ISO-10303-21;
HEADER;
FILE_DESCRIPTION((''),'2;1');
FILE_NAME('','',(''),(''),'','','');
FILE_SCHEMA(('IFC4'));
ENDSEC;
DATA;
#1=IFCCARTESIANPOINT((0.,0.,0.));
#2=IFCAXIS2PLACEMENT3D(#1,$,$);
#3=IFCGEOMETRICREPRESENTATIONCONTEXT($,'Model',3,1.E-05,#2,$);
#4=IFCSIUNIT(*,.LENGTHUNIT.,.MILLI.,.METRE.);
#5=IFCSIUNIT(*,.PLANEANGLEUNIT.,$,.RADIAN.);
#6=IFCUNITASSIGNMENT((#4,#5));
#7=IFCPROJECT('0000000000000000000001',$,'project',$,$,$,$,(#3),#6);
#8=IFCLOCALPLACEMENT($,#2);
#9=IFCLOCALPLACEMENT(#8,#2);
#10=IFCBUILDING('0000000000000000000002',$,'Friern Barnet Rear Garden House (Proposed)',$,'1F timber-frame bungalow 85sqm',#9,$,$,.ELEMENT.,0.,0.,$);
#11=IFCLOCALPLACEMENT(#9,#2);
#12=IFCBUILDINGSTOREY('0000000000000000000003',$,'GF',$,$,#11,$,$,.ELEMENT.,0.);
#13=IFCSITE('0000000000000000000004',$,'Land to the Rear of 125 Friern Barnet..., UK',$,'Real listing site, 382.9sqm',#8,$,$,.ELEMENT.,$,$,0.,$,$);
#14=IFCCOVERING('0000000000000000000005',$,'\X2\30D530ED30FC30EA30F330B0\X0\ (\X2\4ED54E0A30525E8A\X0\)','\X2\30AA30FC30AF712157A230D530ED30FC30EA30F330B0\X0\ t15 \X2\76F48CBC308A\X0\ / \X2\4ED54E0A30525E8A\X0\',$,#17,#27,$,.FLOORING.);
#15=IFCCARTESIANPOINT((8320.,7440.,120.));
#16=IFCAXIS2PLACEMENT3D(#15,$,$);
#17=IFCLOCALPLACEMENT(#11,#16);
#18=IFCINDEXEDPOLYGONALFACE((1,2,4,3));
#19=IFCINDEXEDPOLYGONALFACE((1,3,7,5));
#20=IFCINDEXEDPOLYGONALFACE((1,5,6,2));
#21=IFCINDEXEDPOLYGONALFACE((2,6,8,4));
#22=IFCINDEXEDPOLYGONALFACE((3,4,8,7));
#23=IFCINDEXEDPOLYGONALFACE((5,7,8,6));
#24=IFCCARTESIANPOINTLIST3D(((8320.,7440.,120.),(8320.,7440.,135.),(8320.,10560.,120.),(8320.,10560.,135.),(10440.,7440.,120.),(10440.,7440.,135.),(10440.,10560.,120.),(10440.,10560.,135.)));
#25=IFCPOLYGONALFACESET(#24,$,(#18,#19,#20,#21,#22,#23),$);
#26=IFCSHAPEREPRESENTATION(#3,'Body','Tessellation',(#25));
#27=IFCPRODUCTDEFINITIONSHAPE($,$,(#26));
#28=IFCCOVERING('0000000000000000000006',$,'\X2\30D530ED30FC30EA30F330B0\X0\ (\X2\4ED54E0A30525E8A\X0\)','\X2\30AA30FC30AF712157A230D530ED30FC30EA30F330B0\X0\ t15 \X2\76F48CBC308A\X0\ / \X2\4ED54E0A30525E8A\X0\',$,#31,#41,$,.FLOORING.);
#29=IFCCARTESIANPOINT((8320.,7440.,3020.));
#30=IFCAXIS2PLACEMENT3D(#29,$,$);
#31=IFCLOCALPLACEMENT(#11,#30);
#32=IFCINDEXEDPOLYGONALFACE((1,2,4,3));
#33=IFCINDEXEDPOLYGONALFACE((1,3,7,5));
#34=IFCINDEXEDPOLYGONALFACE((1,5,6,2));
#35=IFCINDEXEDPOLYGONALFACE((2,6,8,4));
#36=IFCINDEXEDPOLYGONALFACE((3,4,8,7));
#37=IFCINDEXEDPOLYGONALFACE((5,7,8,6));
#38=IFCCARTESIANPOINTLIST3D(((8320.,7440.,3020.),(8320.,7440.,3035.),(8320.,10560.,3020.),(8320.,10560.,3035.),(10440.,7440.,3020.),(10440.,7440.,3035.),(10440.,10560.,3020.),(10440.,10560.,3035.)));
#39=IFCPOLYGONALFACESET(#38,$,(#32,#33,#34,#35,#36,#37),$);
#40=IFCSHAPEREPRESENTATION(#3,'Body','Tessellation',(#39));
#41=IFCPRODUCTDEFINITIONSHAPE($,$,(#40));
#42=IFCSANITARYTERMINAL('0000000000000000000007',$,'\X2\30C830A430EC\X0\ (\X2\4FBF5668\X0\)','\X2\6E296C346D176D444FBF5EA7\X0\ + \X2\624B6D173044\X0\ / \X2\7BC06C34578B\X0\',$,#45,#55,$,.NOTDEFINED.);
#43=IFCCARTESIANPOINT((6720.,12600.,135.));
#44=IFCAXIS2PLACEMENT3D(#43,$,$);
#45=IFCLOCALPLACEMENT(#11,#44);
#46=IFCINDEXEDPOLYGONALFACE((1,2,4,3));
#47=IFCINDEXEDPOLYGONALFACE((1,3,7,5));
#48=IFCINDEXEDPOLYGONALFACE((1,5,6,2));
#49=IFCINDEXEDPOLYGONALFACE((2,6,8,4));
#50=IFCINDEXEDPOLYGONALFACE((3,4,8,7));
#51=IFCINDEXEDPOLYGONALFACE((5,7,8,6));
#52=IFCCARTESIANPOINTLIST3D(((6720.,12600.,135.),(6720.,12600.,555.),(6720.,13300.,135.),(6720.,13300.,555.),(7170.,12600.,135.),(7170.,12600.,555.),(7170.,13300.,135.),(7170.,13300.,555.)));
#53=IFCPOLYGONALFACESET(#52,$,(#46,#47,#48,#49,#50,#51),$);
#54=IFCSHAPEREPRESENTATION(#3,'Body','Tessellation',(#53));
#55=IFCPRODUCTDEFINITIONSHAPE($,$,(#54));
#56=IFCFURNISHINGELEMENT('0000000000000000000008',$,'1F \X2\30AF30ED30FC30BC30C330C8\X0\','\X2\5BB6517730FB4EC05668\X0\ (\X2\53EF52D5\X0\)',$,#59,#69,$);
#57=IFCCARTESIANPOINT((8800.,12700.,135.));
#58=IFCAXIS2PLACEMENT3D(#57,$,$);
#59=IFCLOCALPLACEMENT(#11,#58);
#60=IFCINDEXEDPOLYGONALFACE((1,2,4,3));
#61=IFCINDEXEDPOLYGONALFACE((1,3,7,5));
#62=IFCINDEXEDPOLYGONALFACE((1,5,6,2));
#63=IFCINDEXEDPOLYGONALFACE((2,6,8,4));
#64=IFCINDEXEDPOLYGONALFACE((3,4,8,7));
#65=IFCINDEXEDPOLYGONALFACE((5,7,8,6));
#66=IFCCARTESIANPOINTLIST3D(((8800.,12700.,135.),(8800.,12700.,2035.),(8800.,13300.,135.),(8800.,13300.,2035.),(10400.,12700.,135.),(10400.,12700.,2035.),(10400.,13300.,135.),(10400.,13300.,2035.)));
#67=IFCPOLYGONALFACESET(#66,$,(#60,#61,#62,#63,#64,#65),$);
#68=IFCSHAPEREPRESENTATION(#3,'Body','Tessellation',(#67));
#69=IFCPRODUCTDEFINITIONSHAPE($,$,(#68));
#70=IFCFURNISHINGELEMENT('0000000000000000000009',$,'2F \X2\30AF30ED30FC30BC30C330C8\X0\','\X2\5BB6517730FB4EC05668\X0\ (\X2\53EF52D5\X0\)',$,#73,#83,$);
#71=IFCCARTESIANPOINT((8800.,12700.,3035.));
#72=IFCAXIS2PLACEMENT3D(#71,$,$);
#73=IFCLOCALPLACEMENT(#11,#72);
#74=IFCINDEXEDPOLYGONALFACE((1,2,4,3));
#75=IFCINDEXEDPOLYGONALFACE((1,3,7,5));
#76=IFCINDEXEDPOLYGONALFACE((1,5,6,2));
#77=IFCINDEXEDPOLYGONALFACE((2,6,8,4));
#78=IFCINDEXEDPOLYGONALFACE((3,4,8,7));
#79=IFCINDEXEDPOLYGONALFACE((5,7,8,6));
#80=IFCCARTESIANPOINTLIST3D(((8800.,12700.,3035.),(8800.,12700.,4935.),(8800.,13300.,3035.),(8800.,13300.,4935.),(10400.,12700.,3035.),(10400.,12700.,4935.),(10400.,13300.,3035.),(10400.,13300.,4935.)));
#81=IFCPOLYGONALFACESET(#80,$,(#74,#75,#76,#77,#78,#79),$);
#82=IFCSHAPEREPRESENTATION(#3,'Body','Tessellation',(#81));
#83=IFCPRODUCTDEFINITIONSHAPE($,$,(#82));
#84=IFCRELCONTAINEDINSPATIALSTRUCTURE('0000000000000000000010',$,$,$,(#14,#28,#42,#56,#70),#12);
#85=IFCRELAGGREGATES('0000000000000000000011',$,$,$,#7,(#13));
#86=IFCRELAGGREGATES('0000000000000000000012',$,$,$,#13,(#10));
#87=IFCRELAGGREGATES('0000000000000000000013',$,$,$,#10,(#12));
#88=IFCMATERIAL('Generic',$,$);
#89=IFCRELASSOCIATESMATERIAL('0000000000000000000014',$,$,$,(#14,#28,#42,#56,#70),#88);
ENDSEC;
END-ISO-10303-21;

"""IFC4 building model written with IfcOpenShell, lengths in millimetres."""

from ifc_helpers import new_model, si_unit, frame, frame_2d, origin, place, context, project, spatial, rectangle, extrude, material, element, save


model = new_model("IFC4")

# Units and contexts
model_context = context("Model", 3, precision=1e-05, world=origin())
ifc_project = project(units=[si_unit("LENGTHUNIT", "METRE", prefix="MILLI"), si_unit("PLANEANGLEUNIT", "RADIAN")], contexts=[model_context])

# Site, building, storey
site_placement = place(None, origin())
site = spatial("IfcSite", under=ifc_project, at=site_placement, Name="Land to the Rear of 125 Friern Barnet..., UK", ObjectType="Real listing site, 382.9sqm", CompositionType="ELEMENT", RefElevation=0.0)
building_placement = place(site_placement, origin())
building = spatial("IfcBuilding", under=site, at=building_placement, Name="Friern Barnet Rear Garden House (Proposed)", ObjectType="1F timber-frame bungalow 85sqm", CompositionType="ELEMENT", ElevationOfRefHeight=0.0, ElevationOfTerrain=0.0)
storey_placement = place(building_placement, origin())
storey = spatial("IfcBuildingStorey", under=building, at=storey_placement, Name="GF", CompositionType="ELEMENT", Elevation=0.0)

# Shared definitions
ifc_material_1 = material(Name="Generic")

# Coverings
covering_1_placement = place(storey_placement, frame((8320.0, 7440.0, 120.0)))
element("IfcCovering", 1, at=covering_1_placement, inside=storey, material=ifc_material_1, Name="フローリング (仕上げ床)", Description="オーク無垢フローリング t15 直貼り / 仕上げ床", PredefinedType="FLOORING", context=model_context, shape_type="SweptSolid", body=[
    extrude(rectangle(XDim=2120.0, YDim=3120.0, at=frame_2d((1060.0, 1560.0))), frame((8320.0, 7440.0, 120.0)), (0.0, 0.0, 1.0), 15.0),
])
covering_2_placement = place(storey_placement, frame((8320.0, 7440.0, 3020.0)))
element("IfcCovering", 2, at=covering_2_placement, inside=storey, material=ifc_material_1, Name="フローリング (仕上げ床)", Description="オーク無垢フローリング t15 直貼り / 仕上げ床", PredefinedType="FLOORING", context=model_context, shape_type="SweptSolid", body=[
    extrude(rectangle(XDim=2120.0, YDim=3120.0, at=frame_2d((1060.0, 1560.0))), frame((8320.0, 7440.0, 3020.0)), (0.0, 0.0, 1.0), 15.0),
])

# Sanitary terminal
sanitary_terminal_placement = place(storey_placement, frame((6720.0, 12600.0, 135.0)))
element("IfcSanitaryTerminal", 3, at=sanitary_terminal_placement, inside=storey, material=ifc_material_1, Name="トイレ (便器)", Description="温水洗浄便座 + 手洗い / 節水型", PredefinedType="NOTDEFINED", context=model_context, shape_type="SweptSolid", body=[
    extrude(rectangle(XDim=450.0, YDim=700.0, at=frame_2d((225.0, 350.0))), frame((6720.0, 12600.0, 135.0)), (0.0, 0.0, 1.0), 420.0),
])

# Furnishing elements
furnishing_1_placement = place(storey_placement, frame((8800.0, 12700.0, 135.0)))
element("IfcFurnishingElement", 4, at=furnishing_1_placement, inside=storey, material=ifc_material_1, Name="1F クローゼット", Description="家具・什器 (可動)", context=model_context, shape_type="SweptSolid", body=[
    extrude(rectangle(XDim=1600.0, YDim=600.0, at=frame_2d((800.0, 300.0))), frame((8800.0, 12700.0, 135.0)), (0.0, 0.0, 1.0), 1900.0),
])
furnishing_2_placement = place(storey_placement, frame((8800.0, 12700.0, 3035.0)))
element("IfcFurnishingElement", 5, at=furnishing_2_placement, inside=storey, material=ifc_material_1, Name="2F クローゼット", Description="家具・什器 (可動)", context=model_context, shape_type="SweptSolid", body=[
    extrude(rectangle(XDim=1600.0, YDim=600.0, at=frame_2d((800.0, 300.0))), frame((8800.0, 12700.0, 3035.0)), (0.0, 0.0, 1.0), 1900.0),
])

save(model, "model.ifc")
